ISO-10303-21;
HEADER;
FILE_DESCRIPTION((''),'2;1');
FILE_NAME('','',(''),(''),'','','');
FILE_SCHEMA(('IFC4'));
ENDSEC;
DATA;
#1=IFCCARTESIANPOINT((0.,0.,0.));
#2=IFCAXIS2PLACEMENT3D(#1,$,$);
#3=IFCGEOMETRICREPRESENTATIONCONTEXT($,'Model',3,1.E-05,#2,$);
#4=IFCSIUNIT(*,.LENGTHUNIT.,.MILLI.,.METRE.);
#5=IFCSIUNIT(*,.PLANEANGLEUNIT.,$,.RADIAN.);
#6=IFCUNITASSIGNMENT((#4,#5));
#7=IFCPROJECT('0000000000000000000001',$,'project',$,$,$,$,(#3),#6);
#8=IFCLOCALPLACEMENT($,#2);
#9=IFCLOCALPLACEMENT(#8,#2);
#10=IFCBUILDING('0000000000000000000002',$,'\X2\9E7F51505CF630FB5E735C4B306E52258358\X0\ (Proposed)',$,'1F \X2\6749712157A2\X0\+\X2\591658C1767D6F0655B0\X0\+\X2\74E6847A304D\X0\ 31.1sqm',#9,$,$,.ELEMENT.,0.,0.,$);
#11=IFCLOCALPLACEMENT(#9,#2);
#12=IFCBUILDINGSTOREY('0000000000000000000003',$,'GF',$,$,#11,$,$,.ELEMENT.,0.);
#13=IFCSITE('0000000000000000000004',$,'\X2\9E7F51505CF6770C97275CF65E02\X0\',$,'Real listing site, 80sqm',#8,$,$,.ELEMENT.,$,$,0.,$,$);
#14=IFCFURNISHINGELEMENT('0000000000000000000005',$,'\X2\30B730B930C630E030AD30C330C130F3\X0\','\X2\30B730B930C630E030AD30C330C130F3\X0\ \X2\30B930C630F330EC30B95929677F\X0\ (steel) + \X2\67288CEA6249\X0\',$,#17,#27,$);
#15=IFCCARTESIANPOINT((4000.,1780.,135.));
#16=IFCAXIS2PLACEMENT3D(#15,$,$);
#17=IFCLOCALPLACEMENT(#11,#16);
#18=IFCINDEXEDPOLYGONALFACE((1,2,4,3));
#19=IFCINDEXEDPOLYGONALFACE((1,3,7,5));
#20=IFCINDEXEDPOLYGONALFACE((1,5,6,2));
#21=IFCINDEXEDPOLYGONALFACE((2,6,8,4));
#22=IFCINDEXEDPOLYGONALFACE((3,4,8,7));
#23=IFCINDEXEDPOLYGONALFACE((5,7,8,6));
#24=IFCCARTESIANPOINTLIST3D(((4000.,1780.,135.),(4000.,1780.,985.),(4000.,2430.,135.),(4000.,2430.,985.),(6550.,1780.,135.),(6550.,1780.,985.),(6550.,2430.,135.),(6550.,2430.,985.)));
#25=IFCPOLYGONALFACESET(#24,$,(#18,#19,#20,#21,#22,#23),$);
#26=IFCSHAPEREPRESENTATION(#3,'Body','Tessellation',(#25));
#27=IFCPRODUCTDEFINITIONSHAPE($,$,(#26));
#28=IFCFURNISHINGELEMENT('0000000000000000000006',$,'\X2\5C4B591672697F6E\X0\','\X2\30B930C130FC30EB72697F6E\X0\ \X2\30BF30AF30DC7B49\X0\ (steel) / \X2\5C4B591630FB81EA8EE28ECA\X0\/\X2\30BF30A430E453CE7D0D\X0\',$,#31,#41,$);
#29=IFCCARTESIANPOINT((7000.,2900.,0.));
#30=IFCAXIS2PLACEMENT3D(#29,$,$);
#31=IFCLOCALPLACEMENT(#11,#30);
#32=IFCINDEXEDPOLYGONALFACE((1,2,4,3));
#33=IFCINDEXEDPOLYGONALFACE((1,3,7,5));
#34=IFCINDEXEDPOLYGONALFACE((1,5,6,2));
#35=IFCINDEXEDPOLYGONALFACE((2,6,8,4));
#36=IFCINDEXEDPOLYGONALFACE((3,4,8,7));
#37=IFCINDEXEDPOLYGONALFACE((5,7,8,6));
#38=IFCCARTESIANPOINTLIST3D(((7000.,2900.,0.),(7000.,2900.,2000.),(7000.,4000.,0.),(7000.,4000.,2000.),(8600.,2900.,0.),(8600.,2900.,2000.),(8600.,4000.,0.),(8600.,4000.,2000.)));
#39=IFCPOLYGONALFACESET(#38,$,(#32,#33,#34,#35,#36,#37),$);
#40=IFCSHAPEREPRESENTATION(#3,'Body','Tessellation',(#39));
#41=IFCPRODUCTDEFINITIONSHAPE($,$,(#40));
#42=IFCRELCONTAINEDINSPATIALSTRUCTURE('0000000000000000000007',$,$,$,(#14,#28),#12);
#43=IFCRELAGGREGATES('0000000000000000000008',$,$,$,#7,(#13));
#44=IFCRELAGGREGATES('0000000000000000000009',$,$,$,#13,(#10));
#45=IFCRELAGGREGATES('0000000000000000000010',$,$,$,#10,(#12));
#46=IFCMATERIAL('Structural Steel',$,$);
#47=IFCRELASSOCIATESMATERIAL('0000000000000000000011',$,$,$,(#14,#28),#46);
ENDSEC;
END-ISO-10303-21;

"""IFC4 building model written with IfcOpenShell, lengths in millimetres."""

from ifc_helpers import new_model, si_unit, frame, frame_2d, origin, place, context, project, spatial, rectangle, extrude, material, element, save


model = new_model("IFC4")

# Units and contexts
model_context = context("Model", 3, precision=1e-05, world=origin())
ifc_project = project(units=[si_unit("LENGTHUNIT", "METRE", prefix="MILLI"), si_unit("PLANEANGLEUNIT", "RADIAN")], contexts=[model_context])

# Site, building, storey
site_placement = place(None, origin())
site = spatial("IfcSite", under=ifc_project, at=site_placement, Name="鹿児島県霧島市", ObjectType="Real listing site, 80sqm", CompositionType="ELEMENT", RefElevation=0.0)
building_placement = place(site_placement, origin())
building = spatial("IfcBuilding", under=site, at=building_placement, Name="鹿児島・平屋の別荘 (Proposed)", ObjectType="1F 杉無垢+外壁白漆喰+瓦葺き 31.1sqm", CompositionType="ELEMENT", ElevationOfRefHeight=0.0, ElevationOfTerrain=0.0)
storey_placement = place(building_placement, origin())
storey = spatial("IfcBuildingStorey", under=building, at=storey_placement, Name="GF", CompositionType="ELEMENT", Elevation=0.0)

# Shared definitions
ifc_material_1 = material(Name="Structural Steel")

# Furnishing elements
furnishing_1_placement = place(storey_placement, frame((4000.0, 1780.0, 135.0)))
element("IfcFurnishingElement", 1, at=furnishing_1_placement, inside=storey, material=ifc_material_1, Name="システムキッチン", Description="システムキッチン ステンレス天板 (steel) + 木質扉", context=model_context, shape_type="SweptSolid", body=[
    extrude(rectangle(XDim=2550.0, YDim=650.0, at=frame_2d((1275.0, 325.0))), frame((4000.0, 1780.0, 135.0)), (0.0, 0.0, 1.0), 850.0),
])
furnishing_2_placement = place(storey_placement, frame((7000.0, 2900.0, 0.0)))
element("IfcFurnishingElement", 2, at=furnishing_2_placement, inside=storey, material=ifc_material_1, Name="屋外物置", Description="スチール物置 タクボ等 (steel) / 屋外・自転車/タイヤ収納", context=model_context, shape_type="SweptSolid", body=[
    extrude(rectangle(XDim=1600.0, YDim=1100.0, at=frame_2d((800.0, 550.0))), frame((7000.0, 2900.0, 0.0)), (0.0, 0.0, 1.0), 2000.0),
])

save(model, "model.ifc")
